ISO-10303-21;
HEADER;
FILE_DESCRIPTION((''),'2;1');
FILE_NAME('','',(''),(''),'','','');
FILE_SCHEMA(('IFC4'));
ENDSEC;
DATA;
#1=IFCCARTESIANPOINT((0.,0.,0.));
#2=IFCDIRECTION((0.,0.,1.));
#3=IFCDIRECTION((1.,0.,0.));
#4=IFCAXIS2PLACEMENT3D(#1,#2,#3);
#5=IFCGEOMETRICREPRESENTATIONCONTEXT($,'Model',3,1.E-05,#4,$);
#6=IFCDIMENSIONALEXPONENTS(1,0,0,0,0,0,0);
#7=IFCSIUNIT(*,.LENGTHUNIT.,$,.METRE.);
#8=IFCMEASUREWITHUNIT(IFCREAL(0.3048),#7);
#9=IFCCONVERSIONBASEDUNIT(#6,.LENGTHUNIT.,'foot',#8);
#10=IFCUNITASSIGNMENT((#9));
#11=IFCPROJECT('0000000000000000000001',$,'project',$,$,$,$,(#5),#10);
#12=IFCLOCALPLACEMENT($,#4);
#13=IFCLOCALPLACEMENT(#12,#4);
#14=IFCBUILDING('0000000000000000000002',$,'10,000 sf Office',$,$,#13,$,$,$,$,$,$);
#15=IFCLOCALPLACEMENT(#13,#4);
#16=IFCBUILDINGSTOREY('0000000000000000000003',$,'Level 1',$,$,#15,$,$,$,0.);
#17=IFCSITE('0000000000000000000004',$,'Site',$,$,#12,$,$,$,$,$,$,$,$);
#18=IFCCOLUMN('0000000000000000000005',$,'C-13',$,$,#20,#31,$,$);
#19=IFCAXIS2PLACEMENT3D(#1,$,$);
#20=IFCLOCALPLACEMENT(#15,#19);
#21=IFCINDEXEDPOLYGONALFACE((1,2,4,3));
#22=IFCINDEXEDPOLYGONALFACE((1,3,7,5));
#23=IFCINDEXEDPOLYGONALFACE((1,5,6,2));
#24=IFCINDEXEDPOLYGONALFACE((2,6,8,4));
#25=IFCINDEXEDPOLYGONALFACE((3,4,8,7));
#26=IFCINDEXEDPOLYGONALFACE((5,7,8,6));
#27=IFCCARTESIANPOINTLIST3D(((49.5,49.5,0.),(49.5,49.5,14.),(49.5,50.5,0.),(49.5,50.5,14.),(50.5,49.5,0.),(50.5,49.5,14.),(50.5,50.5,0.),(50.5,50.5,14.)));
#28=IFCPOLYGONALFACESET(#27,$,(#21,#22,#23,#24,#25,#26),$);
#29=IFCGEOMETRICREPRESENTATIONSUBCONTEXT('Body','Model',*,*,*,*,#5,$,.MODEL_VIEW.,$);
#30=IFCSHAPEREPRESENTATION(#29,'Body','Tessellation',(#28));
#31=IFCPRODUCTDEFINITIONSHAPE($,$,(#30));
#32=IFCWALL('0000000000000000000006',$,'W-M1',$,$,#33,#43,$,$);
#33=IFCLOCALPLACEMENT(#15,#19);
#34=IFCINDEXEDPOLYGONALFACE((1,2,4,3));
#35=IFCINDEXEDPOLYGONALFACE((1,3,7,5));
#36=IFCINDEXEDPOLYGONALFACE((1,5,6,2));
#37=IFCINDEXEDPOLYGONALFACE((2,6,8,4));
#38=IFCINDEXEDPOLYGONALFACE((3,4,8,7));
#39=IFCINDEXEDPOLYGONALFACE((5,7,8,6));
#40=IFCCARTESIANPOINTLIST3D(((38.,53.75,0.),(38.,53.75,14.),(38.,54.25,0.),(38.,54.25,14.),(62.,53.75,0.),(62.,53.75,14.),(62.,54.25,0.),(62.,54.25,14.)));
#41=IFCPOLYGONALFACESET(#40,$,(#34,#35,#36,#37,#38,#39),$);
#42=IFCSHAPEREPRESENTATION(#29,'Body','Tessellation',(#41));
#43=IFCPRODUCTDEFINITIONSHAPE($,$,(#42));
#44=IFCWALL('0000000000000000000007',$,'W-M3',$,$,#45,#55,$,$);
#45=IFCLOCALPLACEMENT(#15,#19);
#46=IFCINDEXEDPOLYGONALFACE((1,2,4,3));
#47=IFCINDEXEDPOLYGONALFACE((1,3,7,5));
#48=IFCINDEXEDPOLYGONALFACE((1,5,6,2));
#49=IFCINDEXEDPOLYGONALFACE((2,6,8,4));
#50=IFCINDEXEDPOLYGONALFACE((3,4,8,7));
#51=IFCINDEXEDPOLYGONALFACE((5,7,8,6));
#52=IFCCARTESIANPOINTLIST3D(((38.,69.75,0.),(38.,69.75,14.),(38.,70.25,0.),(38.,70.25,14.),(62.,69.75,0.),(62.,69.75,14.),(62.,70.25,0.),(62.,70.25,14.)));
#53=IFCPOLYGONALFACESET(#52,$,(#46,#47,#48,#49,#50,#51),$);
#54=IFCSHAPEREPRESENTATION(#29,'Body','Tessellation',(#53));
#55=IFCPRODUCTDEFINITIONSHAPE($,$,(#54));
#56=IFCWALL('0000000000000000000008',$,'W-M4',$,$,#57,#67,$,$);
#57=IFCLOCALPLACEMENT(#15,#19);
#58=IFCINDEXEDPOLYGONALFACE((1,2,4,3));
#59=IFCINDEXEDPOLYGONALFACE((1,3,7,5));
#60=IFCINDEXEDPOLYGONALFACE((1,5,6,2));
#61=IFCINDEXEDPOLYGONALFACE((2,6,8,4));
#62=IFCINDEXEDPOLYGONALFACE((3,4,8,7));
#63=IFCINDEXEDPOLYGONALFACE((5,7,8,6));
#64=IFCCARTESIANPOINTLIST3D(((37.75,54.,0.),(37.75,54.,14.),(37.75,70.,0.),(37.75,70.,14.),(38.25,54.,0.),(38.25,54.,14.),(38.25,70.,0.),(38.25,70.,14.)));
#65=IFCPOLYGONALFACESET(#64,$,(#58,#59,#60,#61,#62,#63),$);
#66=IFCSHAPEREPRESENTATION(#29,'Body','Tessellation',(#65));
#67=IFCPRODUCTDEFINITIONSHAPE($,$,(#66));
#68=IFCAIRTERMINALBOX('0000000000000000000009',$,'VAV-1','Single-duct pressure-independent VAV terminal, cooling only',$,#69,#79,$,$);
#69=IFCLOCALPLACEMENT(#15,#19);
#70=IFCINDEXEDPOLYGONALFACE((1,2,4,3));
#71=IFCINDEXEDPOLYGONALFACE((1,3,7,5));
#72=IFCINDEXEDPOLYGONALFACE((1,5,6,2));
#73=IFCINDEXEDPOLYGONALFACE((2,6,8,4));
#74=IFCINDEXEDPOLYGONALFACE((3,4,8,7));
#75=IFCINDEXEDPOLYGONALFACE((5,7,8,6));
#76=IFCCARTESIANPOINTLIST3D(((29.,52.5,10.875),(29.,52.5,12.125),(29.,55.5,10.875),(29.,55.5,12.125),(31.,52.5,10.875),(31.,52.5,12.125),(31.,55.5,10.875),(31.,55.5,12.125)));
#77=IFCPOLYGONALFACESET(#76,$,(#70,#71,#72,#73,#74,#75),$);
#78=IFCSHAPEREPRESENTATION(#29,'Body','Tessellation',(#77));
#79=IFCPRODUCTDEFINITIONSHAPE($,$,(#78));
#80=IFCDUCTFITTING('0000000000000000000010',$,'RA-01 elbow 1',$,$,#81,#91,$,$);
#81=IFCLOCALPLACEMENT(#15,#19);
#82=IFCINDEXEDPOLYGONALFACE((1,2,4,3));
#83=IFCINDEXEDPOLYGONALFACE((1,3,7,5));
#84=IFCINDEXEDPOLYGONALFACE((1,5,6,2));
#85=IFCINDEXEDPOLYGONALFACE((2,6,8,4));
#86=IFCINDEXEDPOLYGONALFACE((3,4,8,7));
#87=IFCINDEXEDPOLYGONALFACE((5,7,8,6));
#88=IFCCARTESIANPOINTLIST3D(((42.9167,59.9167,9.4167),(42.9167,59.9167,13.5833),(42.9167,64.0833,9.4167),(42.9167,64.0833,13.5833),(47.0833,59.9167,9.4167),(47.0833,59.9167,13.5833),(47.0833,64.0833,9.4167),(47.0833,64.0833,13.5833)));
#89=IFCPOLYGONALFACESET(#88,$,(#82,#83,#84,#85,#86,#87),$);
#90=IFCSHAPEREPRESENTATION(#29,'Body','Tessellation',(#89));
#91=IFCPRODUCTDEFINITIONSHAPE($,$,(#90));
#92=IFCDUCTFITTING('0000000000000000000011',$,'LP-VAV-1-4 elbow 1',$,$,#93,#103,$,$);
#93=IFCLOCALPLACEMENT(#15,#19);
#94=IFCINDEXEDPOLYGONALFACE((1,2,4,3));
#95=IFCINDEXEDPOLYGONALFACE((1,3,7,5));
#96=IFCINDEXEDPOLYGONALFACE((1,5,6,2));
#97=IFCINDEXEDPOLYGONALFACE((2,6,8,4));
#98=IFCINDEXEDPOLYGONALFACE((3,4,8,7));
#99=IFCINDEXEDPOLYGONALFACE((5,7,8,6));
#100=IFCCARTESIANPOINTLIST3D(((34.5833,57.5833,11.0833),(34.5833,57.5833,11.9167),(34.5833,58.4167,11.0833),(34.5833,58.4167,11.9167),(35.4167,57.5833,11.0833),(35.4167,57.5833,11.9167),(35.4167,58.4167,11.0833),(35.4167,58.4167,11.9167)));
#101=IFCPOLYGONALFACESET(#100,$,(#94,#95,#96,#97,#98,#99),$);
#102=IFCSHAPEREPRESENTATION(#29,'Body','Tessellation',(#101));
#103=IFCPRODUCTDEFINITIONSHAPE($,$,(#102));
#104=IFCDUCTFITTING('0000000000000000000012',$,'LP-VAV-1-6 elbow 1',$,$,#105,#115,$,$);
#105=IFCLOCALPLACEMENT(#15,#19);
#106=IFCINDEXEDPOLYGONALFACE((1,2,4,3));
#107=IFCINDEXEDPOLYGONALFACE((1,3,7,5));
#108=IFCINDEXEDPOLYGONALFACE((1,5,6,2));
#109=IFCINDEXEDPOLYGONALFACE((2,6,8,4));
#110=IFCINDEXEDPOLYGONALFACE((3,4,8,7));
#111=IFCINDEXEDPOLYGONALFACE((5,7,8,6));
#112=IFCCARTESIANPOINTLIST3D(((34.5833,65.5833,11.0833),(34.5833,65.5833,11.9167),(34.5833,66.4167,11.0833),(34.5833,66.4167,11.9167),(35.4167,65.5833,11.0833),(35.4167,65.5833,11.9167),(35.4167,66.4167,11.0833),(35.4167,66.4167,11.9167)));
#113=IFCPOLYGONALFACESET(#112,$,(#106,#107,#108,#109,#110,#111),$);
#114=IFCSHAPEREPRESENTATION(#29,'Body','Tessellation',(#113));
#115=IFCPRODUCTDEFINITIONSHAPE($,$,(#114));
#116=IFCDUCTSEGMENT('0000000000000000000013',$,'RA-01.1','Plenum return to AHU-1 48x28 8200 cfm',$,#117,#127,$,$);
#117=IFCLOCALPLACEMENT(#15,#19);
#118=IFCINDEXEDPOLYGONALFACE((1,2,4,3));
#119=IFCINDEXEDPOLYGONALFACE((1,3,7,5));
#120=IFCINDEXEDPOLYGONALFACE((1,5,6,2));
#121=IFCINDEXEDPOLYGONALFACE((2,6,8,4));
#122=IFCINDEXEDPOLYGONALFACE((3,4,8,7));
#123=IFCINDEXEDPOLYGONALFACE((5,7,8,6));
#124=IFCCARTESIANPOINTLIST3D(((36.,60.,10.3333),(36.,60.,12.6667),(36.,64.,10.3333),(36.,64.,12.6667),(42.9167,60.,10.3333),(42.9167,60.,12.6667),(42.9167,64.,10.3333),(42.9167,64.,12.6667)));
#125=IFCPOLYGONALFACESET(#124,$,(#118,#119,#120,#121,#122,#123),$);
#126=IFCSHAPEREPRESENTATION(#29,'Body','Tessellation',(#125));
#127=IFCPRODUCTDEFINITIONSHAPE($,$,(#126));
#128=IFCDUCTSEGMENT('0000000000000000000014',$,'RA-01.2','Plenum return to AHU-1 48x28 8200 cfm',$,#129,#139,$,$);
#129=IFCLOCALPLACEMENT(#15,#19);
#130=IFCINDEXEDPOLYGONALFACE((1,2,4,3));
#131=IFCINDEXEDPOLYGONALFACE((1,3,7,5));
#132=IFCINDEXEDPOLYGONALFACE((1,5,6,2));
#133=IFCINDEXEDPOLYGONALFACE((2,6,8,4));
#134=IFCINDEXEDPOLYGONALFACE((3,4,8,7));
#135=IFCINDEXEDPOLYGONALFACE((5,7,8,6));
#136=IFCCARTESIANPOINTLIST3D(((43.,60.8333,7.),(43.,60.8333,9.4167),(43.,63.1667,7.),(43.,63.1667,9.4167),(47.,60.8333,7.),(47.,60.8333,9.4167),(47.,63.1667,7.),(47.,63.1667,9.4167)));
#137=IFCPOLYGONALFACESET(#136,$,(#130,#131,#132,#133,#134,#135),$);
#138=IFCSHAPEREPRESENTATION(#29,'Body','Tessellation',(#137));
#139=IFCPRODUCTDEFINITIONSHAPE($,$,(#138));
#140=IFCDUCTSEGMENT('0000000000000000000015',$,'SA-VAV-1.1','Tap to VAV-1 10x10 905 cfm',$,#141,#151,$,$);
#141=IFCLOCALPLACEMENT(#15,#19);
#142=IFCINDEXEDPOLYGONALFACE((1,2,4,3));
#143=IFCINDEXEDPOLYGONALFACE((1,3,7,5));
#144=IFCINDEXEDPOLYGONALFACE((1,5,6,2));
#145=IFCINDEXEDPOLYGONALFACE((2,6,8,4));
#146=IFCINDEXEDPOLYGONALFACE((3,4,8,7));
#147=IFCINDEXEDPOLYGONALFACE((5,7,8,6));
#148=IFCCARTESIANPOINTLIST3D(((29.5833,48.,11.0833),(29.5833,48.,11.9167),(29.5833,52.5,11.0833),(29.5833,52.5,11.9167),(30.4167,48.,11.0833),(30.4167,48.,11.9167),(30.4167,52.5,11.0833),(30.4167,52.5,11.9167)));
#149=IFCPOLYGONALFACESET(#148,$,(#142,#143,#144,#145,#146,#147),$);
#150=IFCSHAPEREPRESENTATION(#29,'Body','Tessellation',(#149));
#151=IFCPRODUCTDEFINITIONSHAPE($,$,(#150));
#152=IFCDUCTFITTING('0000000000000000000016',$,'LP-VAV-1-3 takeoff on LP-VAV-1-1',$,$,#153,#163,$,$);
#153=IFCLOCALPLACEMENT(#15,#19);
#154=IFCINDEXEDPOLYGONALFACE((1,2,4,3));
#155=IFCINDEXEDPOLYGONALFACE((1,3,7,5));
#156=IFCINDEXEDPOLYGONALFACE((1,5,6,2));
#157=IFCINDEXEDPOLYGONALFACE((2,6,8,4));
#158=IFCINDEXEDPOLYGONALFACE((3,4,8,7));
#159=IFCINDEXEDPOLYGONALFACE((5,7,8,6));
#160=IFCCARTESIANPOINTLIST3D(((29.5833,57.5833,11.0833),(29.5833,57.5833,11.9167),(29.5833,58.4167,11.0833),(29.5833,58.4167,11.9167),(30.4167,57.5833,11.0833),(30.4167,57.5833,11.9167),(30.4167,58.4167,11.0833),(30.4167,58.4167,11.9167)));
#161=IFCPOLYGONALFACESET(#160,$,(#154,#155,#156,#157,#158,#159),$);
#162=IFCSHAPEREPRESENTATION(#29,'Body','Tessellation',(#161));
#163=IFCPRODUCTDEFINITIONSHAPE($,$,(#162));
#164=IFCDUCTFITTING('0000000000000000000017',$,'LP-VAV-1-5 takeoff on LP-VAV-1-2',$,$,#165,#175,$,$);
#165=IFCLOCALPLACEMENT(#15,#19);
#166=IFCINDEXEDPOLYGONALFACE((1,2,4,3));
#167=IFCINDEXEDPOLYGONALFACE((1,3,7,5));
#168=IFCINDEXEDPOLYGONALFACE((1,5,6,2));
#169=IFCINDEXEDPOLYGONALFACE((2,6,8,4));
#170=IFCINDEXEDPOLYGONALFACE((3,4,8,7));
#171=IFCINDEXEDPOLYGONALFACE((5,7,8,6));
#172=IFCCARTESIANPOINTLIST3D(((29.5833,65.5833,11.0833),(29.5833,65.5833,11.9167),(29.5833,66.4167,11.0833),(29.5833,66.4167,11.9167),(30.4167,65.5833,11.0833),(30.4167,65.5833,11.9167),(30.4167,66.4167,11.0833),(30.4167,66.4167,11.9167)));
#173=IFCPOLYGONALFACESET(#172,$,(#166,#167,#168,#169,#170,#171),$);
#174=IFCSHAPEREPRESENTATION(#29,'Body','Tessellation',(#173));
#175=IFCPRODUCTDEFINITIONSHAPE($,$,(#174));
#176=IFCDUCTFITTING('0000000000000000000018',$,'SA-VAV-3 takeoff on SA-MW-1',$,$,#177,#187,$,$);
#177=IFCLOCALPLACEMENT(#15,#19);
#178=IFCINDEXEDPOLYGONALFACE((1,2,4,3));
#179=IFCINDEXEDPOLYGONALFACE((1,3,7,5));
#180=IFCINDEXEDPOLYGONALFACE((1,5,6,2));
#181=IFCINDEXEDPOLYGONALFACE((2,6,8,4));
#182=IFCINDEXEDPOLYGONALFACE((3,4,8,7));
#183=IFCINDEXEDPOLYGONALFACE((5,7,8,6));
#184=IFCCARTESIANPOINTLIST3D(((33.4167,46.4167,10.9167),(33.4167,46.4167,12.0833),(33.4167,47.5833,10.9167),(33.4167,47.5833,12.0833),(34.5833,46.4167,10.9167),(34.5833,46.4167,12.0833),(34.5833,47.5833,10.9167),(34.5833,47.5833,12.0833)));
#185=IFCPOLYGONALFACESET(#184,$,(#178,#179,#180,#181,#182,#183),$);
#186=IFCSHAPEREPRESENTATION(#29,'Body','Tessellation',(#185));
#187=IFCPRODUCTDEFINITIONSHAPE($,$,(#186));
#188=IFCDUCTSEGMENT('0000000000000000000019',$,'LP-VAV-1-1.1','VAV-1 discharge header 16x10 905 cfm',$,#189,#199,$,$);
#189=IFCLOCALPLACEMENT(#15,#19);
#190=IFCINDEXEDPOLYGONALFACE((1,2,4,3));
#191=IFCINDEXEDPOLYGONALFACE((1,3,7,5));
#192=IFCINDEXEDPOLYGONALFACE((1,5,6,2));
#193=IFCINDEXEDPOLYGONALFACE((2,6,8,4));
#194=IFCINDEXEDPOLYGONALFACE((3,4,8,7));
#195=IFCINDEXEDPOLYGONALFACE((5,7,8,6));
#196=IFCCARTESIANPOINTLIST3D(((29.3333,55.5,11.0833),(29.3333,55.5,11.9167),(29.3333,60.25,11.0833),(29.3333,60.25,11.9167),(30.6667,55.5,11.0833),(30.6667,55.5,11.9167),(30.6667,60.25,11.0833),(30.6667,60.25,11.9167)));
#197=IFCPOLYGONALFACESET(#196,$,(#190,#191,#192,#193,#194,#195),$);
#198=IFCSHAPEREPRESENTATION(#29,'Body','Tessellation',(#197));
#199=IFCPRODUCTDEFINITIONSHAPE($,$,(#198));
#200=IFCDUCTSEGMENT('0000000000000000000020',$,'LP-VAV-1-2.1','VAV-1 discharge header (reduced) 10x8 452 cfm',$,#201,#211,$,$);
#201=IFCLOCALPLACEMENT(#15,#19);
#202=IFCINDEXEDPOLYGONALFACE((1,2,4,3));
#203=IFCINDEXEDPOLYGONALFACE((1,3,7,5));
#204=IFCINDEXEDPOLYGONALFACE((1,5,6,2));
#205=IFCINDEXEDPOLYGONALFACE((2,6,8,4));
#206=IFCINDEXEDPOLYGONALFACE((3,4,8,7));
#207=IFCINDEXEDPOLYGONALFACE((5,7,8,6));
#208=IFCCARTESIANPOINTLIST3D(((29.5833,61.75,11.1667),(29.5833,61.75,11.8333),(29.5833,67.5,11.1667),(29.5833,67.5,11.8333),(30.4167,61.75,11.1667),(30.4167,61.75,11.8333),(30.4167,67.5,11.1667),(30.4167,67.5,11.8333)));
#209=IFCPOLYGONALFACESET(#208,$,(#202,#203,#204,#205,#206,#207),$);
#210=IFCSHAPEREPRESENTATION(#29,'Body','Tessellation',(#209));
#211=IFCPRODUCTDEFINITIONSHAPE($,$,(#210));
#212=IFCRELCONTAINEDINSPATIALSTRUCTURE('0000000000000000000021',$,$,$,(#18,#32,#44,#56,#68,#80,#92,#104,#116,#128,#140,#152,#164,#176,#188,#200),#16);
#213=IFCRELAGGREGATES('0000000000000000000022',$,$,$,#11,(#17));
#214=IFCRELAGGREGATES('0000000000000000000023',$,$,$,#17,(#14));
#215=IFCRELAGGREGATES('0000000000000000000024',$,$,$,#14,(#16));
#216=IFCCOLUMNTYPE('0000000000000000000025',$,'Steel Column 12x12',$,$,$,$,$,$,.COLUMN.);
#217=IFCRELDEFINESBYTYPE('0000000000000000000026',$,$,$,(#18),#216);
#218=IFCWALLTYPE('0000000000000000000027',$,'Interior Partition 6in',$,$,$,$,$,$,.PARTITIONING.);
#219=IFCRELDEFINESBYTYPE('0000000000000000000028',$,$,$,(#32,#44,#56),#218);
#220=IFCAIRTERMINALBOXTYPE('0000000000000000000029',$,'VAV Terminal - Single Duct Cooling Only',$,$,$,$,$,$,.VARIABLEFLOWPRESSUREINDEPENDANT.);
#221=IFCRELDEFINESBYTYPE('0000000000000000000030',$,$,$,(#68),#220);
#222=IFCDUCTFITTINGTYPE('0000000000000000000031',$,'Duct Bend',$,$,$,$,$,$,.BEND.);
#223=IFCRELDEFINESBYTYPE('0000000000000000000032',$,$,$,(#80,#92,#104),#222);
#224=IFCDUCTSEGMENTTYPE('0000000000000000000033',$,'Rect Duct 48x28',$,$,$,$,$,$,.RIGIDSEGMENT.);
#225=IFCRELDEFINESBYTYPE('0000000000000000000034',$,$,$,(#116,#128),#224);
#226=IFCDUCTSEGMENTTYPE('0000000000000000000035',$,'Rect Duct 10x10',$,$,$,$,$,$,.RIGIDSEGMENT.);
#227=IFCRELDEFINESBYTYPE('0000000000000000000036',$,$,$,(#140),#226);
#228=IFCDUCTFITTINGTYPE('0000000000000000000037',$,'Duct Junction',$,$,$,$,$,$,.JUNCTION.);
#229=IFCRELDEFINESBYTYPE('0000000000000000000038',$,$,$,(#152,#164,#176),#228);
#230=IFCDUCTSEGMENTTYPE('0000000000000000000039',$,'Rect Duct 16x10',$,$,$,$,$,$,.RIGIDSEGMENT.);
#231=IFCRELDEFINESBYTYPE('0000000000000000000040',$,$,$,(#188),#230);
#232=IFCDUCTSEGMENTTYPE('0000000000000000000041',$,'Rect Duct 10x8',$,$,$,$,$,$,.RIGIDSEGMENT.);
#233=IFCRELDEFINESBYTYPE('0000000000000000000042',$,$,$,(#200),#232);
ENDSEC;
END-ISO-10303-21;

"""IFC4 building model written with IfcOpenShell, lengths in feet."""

from ifc_helpers import new_model, entity, si_unit, converted_unit, frame, origin_with_axes, place, context, subcontext, project, spatial, rectangle, extrude, type_object, element, save


model = new_model("IFC4")

# Units and contexts
model_context = context("Model", 3, precision=1e-05, world=origin_with_axes())
body_context = subcontext(model_context, "Body", "Model", "MODEL_VIEW")
ifc_project = project(units=[converted_unit("LENGTHUNIT", "foot", entity("IfcReal", 0.3048), si_unit("LENGTHUNIT", "METRE"), dimensions=[1, 0, 0, 0, 0, 0, 0])], contexts=[model_context])

# Site, building, storey
site_placement = place(None, origin_with_axes())
site = spatial("IfcSite", under=ifc_project, at=site_placement, Name="Site")
building_placement = place(site_placement, origin_with_axes())
building = spatial("IfcBuilding", under=site, at=building_placement, Name="10,000 sf Office")
storey_placement = place(building_placement, origin_with_axes())
storey = spatial("IfcBuildingStorey", under=building, at=storey_placement, Name="Level 1", Elevation=0.0)

# Column
column_type = type_object("IfcColumnType", Name="Steel Column 12x12", PredefinedType="COLUMN")
column_placement = place(storey_placement, frame((50.0, 50.0, 0.0), z_axis=(0.0, 0.0, 1.0), x_axis=(1.0, 0.0, 0.0)))
element("IfcColumn", 1, at=column_placement, inside=storey, type_object=column_type, Name="C-13", context=body_context, shape_type="SweptSolid", body=[
    extrude(rectangle(XDim=1.0, YDim=1.0), None, (0.0, 0.0, 1.0), 14.0),
])

# Walls
wall_type = type_object("IfcWallType", Name="Interior Partition 6in", PredefinedType="PARTITIONING")
for number, where, z_axis, x_axis, name in (
    (2, (50.0, 54.0, 0.0), (0.0, 0.0, 1.0), (1.0, 0.0, 0.0), "W-M1"),
    (3, (50.0, 70.0, 0.0), (0.0, 0.0, 1.0), (-1.0, 0.0, 0.0), "W-M3"),
):
    element("IfcWall", number, at=place(storey_placement, frame(where, z_axis=z_axis, x_axis=x_axis)), inside=storey, type_object=wall_type, Name=name, context=body_context, shape_type="SweptSolid", body=[
        extrude(rectangle(XDim=24.0, YDim=0.5), None, (0.0, 0.0, 1.0), 14.0),
    ])
wall_placement = place(storey_placement, frame((38.0, 62.0, 0.0), z_axis=(0.0, 0.0, 1.0), x_axis=(0.0, -1.0, 0.0)))
element("IfcWall", 4, at=wall_placement, inside=storey, type_object=wall_type, Name="W-M4", context=body_context, shape_type="SweptSolid", body=[
    extrude(rectangle(XDim=16.0, YDim=0.5), None, (0.0, 0.0, 1.0), 14.0),
])

# Air terminal box
air_terminal_box_type = type_object("IfcAirTerminalBoxType", Name="VAV Terminal - Single Duct Cooling Only", PredefinedType="VARIABLEFLOWPRESSUREINDEPENDANT")
air_terminal_box_placement = place(storey_placement, frame((30.0, 54.0, 10.875), z_axis=(0.0, 0.0, 1.0), x_axis=(0.0, 1.0, 0.0)))
element("IfcAirTerminalBox", 5, at=air_terminal_box_placement, inside=storey, type_object=air_terminal_box_type, Name="VAV-1", Description="Single-duct pressure-independent VAV terminal, cooling only", context=body_context, shape_type="SweptSolid", body=[
    extrude(rectangle(XDim=3.0, YDim=2.0), None, (0.0, 0.0, 1.0), 1.25),
])

# Duct fittings
duct_fitting_type_1 = type_object("IfcDuctFittingType", Name="Duct Bend", PredefinedType="BEND")
duct_fitting_1_placement = place(storey_placement, frame((45.0, 62.0, 9.4167), z_axis=(0.0, 0.0, 1.0), x_axis=(1.0, 0.0, 0.0)))
element("IfcDuctFitting", 6, at=duct_fitting_1_placement, inside=storey, type_object=duct_fitting_type_1, Name="RA-01 elbow 1", context=body_context, shape_type="SweptSolid", body=[
    extrude(rectangle(XDim=4.1667, YDim=4.1667), None, (0.0, 0.0, 1.0), 4.1667),
])
for number, where, z_axis, x_axis, name in (
    (7, (35.0, 58.0, 11.0833), (0.0, 0.0, 1.0), (1.0, 0.0, 0.0), "LP-VAV-1-4 elbow 1"),
    (8, (35.0, 66.0, 11.0833), (0.0, 0.0, 1.0), (1.0, 0.0, 0.0), "LP-VAV-1-6 elbow 1"),
):
    element("IfcDuctFitting", number, at=place(storey_placement, frame(where, z_axis=z_axis, x_axis=x_axis)), inside=storey, type_object=duct_fitting_type_1, Name=name, context=body_context, shape_type="SweptSolid", body=[
        extrude(rectangle(XDim=0.8333, YDim=0.8333), None, (0.0, 0.0, 1.0), 0.8333),
    ])

# Duct segments
duct_segment_type_1 = type_object("IfcDuctSegmentType", Name="Rect Duct 48x28", PredefinedType="RIGIDSEGMENT")
duct_segment_1_placement = place(storey_placement, frame((36.0, 62.0, 11.5), z_axis=(1.0, 0.0, 0.0), x_axis=(0.0, 1.0, 0.0)))
element("IfcDuctSegment", 9, at=duct_segment_1_placement, inside=storey, type_object=duct_segment_type_1, Name="RA-01.1", Description="Plenum return to AHU-1 48x28 8200 cfm", context=body_context, shape_type="SweptSolid", body=[
    extrude(rectangle(XDim=4.0, YDim=2.3333), None, (0.0, 0.0, 1.0), 6.9167),
])
duct_segment_2_placement = place(storey_placement, frame((45.0, 62.0, 9.4167), z_axis=(0.0, 0.0, -1.0), x_axis=(1.0, 0.0, 0.0)))
element("IfcDuctSegment", 10, at=duct_segment_2_placement, inside=storey, type_object=duct_segment_type_1, Name="RA-01.2", Description="Plenum return to AHU-1 48x28 8200 cfm", context=body_context, shape_type="SweptSolid", body=[
    extrude(rectangle(XDim=4.0, YDim=2.3333), None, (0.0, 0.0, 1.0), 2.4167),
])
duct_segment_type_2 = type_object("IfcDuctSegmentType", Name="Rect Duct 10x10", PredefinedType="RIGIDSEGMENT")
duct_segment_3_placement = place(storey_placement, frame((30.0, 48.0, 11.5), z_axis=(0.0, 1.0, 0.0), x_axis=(-1.0, 0.0, 0.0)))
element("IfcDuctSegment", 11, at=duct_segment_3_placement, inside=storey, type_object=duct_segment_type_2, Name="SA-VAV-1.1", Description="Tap to VAV-1 10x10 905 cfm", context=body_context, shape_type="SweptSolid", body=[
    extrude(rectangle(XDim=0.8333, YDim=0.8333), None, (0.0, 0.0, 1.0), 4.5),
])

# Duct fittings
duct_fitting_type_2 = type_object("IfcDuctFittingType", Name="Duct Junction", PredefinedType="JUNCTION")
for number, where, z_axis, x_axis, name in (
    (12, (30.0, 58.0, 11.0833), (0.0, 0.0, 1.0), (1.0, 0.0, 0.0), "LP-VAV-1-3 takeoff on LP-VAV-1-1"),
    (13, (30.0, 66.0, 11.0833), (0.0, 0.0, 1.0), (1.0, 0.0, 0.0), "LP-VAV-1-5 takeoff on LP-VAV-1-2"),
):
    element("IfcDuctFitting", number, at=place(storey_placement, frame(where, z_axis=z_axis, x_axis=x_axis)), inside=storey, type_object=duct_fitting_type_2, Name=name, context=body_context, shape_type="SweptSolid", body=[
        extrude(rectangle(XDim=0.8333, YDim=0.8333), None, (0.0, 0.0, 1.0), 0.8333),
    ])
duct_fitting_2_placement = place(storey_placement, frame((34.0, 47.0, 10.9167), z_axis=(0.0, 0.0, 1.0), x_axis=(1.0, 0.0, 0.0)))
element("IfcDuctFitting", 14, at=duct_fitting_2_placement, inside=storey, type_object=duct_fitting_type_2, Name="SA-VAV-3 takeoff on SA-MW-1", context=body_context, shape_type="SweptSolid", body=[
    extrude(rectangle(XDim=1.1667, YDim=1.1667), None, (0.0, 0.0, 1.0), 1.1667),
])

# Duct segments
duct_segment_type_3 = type_object("IfcDuctSegmentType", Name="Rect Duct 16x10", PredefinedType="RIGIDSEGMENT")
duct_segment_4_placement = place(storey_placement, frame((30.0, 55.5, 11.5), z_axis=(0.0, 1.0, 0.0), x_axis=(-1.0, 0.0, 0.0)))
element("IfcDuctSegment", 15, at=duct_segment_4_placement, inside=storey, type_object=duct_segment_type_3, Name="LP-VAV-1-1.1", Description="VAV-1 discharge header 16x10 905 cfm", context=body_context, shape_type="SweptSolid", body=[
    extrude(rectangle(XDim=1.3333, YDim=0.8333), None, (0.0, 0.0, 1.0), 4.75),
])
duct_segment_type_4 = type_object("IfcDuctSegmentType", Name="Rect Duct 10x8", PredefinedType="RIGIDSEGMENT")
duct_segment_5_placement = place(storey_placement, frame((30.0, 61.75, 11.5), z_axis=(0.0, 1.0, 0.0), x_axis=(-1.0, 0.0, 0.0)))
element("IfcDuctSegment", 16, at=duct_segment_5_placement, inside=storey, type_object=duct_segment_type_4, Name="LP-VAV-1-2.1", Description="VAV-1 discharge header (reduced) 10x8 452 cfm", context=body_context, shape_type="SweptSolid", body=[
    extrude(rectangle(XDim=0.8333, YDim=0.6667), None, (0.0, 0.0, 1.0), 5.75),
])

save(model, "model.ifc")
